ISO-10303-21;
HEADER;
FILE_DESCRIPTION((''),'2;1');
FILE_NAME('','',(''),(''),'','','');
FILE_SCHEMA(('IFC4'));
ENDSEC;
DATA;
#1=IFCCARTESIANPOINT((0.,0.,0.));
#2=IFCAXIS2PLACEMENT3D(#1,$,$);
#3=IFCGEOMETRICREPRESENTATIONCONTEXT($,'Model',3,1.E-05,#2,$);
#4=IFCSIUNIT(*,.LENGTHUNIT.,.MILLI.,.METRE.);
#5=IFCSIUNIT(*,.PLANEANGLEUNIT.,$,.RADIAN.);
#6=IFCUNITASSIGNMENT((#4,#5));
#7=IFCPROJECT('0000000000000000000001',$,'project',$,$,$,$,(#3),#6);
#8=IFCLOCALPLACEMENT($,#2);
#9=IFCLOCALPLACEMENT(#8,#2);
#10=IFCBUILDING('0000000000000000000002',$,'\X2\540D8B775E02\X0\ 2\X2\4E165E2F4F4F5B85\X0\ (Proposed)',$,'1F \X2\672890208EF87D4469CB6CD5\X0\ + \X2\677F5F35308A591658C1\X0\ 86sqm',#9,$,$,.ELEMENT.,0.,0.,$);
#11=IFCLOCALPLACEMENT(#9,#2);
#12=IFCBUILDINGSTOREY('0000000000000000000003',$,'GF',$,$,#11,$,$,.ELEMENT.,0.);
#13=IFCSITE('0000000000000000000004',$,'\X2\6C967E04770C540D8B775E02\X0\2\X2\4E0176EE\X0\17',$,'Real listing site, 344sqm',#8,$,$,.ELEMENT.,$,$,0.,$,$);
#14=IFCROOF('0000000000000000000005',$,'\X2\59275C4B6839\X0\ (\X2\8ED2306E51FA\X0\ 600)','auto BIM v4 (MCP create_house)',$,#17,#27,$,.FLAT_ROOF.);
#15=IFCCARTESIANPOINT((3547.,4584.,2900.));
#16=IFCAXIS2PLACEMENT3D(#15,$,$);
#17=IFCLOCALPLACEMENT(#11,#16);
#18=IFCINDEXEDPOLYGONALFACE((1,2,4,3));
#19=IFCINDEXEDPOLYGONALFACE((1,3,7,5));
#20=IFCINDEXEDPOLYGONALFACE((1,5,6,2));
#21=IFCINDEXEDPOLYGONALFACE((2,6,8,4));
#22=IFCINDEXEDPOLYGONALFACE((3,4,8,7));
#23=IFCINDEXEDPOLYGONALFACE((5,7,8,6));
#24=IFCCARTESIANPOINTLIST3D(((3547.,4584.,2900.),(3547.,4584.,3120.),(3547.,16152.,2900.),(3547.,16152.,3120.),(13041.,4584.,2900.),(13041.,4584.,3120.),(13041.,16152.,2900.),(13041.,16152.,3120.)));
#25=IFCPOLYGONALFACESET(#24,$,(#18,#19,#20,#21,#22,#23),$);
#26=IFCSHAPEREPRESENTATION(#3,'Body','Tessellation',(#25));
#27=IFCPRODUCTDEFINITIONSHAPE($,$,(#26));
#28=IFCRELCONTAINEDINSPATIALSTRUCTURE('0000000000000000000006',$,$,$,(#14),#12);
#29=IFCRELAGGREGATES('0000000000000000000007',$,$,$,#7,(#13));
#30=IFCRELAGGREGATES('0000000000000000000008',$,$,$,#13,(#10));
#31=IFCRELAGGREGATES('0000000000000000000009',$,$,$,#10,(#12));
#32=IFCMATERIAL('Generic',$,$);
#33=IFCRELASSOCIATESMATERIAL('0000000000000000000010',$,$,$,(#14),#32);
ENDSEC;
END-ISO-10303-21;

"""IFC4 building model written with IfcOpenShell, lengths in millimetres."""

from ifc_helpers import new_model, si_unit, frame, frame_2d, origin, place, context, project, spatial, rectangle, extrude, material, element, save


model = new_model("IFC4")

# Units and contexts
model_context = context("Model", 3, precision=1e-05, world=origin())
ifc_project = project(units=[si_unit("LENGTHUNIT", "METRE", prefix="MILLI"), si_unit("PLANEANGLEUNIT", "RADIAN")], contexts=[model_context])

# Site, building, storey
site_placement = place(None, origin())
site = spatial("IfcSite", under=ifc_project, at=site_placement, Name="沖縄県名護市2丁目17", ObjectType="Real listing site, 344sqm", CompositionType="ELEMENT", RefElevation=0.0)
building_placement = place(site_placement, origin())
building = spatial("IfcBuilding", under=site, at=building_placement, Name="名護市 2世帯住宅 (Proposed)", ObjectType="1F 木造軸組構法 + 板張り外壁 86sqm", CompositionType="ELEMENT", ElevationOfRefHeight=0.0, ElevationOfTerrain=0.0)
storey_placement = place(building_placement, origin())
storey = spatial("IfcBuildingStorey", under=building, at=storey_placement, Name="GF", CompositionType="ELEMENT", Elevation=0.0)

# Shared definitions
ifc_material = material(Name="Generic")

# Roof
roof_placement = place(storey_placement, frame((3547.0, 4584.0, 2900.0)))
element("IfcRoof", 1, at=roof_placement, inside=storey, material=ifc_material, Name="大屋根 (軒の出 600)", Description="auto BIM v4 (MCP create_house)", PredefinedType="FLAT_ROOF", context=model_context, shape_type="SweptSolid", body=[
    extrude(rectangle(XDim=9494.0, YDim=11568.0, at=frame_2d((4747.0, 5784.0))), frame((3547.0, 4584.0, 2900.0)), (0.0, 0.0, 1.0), 220.0),
])

save(model, "model.ifc")
